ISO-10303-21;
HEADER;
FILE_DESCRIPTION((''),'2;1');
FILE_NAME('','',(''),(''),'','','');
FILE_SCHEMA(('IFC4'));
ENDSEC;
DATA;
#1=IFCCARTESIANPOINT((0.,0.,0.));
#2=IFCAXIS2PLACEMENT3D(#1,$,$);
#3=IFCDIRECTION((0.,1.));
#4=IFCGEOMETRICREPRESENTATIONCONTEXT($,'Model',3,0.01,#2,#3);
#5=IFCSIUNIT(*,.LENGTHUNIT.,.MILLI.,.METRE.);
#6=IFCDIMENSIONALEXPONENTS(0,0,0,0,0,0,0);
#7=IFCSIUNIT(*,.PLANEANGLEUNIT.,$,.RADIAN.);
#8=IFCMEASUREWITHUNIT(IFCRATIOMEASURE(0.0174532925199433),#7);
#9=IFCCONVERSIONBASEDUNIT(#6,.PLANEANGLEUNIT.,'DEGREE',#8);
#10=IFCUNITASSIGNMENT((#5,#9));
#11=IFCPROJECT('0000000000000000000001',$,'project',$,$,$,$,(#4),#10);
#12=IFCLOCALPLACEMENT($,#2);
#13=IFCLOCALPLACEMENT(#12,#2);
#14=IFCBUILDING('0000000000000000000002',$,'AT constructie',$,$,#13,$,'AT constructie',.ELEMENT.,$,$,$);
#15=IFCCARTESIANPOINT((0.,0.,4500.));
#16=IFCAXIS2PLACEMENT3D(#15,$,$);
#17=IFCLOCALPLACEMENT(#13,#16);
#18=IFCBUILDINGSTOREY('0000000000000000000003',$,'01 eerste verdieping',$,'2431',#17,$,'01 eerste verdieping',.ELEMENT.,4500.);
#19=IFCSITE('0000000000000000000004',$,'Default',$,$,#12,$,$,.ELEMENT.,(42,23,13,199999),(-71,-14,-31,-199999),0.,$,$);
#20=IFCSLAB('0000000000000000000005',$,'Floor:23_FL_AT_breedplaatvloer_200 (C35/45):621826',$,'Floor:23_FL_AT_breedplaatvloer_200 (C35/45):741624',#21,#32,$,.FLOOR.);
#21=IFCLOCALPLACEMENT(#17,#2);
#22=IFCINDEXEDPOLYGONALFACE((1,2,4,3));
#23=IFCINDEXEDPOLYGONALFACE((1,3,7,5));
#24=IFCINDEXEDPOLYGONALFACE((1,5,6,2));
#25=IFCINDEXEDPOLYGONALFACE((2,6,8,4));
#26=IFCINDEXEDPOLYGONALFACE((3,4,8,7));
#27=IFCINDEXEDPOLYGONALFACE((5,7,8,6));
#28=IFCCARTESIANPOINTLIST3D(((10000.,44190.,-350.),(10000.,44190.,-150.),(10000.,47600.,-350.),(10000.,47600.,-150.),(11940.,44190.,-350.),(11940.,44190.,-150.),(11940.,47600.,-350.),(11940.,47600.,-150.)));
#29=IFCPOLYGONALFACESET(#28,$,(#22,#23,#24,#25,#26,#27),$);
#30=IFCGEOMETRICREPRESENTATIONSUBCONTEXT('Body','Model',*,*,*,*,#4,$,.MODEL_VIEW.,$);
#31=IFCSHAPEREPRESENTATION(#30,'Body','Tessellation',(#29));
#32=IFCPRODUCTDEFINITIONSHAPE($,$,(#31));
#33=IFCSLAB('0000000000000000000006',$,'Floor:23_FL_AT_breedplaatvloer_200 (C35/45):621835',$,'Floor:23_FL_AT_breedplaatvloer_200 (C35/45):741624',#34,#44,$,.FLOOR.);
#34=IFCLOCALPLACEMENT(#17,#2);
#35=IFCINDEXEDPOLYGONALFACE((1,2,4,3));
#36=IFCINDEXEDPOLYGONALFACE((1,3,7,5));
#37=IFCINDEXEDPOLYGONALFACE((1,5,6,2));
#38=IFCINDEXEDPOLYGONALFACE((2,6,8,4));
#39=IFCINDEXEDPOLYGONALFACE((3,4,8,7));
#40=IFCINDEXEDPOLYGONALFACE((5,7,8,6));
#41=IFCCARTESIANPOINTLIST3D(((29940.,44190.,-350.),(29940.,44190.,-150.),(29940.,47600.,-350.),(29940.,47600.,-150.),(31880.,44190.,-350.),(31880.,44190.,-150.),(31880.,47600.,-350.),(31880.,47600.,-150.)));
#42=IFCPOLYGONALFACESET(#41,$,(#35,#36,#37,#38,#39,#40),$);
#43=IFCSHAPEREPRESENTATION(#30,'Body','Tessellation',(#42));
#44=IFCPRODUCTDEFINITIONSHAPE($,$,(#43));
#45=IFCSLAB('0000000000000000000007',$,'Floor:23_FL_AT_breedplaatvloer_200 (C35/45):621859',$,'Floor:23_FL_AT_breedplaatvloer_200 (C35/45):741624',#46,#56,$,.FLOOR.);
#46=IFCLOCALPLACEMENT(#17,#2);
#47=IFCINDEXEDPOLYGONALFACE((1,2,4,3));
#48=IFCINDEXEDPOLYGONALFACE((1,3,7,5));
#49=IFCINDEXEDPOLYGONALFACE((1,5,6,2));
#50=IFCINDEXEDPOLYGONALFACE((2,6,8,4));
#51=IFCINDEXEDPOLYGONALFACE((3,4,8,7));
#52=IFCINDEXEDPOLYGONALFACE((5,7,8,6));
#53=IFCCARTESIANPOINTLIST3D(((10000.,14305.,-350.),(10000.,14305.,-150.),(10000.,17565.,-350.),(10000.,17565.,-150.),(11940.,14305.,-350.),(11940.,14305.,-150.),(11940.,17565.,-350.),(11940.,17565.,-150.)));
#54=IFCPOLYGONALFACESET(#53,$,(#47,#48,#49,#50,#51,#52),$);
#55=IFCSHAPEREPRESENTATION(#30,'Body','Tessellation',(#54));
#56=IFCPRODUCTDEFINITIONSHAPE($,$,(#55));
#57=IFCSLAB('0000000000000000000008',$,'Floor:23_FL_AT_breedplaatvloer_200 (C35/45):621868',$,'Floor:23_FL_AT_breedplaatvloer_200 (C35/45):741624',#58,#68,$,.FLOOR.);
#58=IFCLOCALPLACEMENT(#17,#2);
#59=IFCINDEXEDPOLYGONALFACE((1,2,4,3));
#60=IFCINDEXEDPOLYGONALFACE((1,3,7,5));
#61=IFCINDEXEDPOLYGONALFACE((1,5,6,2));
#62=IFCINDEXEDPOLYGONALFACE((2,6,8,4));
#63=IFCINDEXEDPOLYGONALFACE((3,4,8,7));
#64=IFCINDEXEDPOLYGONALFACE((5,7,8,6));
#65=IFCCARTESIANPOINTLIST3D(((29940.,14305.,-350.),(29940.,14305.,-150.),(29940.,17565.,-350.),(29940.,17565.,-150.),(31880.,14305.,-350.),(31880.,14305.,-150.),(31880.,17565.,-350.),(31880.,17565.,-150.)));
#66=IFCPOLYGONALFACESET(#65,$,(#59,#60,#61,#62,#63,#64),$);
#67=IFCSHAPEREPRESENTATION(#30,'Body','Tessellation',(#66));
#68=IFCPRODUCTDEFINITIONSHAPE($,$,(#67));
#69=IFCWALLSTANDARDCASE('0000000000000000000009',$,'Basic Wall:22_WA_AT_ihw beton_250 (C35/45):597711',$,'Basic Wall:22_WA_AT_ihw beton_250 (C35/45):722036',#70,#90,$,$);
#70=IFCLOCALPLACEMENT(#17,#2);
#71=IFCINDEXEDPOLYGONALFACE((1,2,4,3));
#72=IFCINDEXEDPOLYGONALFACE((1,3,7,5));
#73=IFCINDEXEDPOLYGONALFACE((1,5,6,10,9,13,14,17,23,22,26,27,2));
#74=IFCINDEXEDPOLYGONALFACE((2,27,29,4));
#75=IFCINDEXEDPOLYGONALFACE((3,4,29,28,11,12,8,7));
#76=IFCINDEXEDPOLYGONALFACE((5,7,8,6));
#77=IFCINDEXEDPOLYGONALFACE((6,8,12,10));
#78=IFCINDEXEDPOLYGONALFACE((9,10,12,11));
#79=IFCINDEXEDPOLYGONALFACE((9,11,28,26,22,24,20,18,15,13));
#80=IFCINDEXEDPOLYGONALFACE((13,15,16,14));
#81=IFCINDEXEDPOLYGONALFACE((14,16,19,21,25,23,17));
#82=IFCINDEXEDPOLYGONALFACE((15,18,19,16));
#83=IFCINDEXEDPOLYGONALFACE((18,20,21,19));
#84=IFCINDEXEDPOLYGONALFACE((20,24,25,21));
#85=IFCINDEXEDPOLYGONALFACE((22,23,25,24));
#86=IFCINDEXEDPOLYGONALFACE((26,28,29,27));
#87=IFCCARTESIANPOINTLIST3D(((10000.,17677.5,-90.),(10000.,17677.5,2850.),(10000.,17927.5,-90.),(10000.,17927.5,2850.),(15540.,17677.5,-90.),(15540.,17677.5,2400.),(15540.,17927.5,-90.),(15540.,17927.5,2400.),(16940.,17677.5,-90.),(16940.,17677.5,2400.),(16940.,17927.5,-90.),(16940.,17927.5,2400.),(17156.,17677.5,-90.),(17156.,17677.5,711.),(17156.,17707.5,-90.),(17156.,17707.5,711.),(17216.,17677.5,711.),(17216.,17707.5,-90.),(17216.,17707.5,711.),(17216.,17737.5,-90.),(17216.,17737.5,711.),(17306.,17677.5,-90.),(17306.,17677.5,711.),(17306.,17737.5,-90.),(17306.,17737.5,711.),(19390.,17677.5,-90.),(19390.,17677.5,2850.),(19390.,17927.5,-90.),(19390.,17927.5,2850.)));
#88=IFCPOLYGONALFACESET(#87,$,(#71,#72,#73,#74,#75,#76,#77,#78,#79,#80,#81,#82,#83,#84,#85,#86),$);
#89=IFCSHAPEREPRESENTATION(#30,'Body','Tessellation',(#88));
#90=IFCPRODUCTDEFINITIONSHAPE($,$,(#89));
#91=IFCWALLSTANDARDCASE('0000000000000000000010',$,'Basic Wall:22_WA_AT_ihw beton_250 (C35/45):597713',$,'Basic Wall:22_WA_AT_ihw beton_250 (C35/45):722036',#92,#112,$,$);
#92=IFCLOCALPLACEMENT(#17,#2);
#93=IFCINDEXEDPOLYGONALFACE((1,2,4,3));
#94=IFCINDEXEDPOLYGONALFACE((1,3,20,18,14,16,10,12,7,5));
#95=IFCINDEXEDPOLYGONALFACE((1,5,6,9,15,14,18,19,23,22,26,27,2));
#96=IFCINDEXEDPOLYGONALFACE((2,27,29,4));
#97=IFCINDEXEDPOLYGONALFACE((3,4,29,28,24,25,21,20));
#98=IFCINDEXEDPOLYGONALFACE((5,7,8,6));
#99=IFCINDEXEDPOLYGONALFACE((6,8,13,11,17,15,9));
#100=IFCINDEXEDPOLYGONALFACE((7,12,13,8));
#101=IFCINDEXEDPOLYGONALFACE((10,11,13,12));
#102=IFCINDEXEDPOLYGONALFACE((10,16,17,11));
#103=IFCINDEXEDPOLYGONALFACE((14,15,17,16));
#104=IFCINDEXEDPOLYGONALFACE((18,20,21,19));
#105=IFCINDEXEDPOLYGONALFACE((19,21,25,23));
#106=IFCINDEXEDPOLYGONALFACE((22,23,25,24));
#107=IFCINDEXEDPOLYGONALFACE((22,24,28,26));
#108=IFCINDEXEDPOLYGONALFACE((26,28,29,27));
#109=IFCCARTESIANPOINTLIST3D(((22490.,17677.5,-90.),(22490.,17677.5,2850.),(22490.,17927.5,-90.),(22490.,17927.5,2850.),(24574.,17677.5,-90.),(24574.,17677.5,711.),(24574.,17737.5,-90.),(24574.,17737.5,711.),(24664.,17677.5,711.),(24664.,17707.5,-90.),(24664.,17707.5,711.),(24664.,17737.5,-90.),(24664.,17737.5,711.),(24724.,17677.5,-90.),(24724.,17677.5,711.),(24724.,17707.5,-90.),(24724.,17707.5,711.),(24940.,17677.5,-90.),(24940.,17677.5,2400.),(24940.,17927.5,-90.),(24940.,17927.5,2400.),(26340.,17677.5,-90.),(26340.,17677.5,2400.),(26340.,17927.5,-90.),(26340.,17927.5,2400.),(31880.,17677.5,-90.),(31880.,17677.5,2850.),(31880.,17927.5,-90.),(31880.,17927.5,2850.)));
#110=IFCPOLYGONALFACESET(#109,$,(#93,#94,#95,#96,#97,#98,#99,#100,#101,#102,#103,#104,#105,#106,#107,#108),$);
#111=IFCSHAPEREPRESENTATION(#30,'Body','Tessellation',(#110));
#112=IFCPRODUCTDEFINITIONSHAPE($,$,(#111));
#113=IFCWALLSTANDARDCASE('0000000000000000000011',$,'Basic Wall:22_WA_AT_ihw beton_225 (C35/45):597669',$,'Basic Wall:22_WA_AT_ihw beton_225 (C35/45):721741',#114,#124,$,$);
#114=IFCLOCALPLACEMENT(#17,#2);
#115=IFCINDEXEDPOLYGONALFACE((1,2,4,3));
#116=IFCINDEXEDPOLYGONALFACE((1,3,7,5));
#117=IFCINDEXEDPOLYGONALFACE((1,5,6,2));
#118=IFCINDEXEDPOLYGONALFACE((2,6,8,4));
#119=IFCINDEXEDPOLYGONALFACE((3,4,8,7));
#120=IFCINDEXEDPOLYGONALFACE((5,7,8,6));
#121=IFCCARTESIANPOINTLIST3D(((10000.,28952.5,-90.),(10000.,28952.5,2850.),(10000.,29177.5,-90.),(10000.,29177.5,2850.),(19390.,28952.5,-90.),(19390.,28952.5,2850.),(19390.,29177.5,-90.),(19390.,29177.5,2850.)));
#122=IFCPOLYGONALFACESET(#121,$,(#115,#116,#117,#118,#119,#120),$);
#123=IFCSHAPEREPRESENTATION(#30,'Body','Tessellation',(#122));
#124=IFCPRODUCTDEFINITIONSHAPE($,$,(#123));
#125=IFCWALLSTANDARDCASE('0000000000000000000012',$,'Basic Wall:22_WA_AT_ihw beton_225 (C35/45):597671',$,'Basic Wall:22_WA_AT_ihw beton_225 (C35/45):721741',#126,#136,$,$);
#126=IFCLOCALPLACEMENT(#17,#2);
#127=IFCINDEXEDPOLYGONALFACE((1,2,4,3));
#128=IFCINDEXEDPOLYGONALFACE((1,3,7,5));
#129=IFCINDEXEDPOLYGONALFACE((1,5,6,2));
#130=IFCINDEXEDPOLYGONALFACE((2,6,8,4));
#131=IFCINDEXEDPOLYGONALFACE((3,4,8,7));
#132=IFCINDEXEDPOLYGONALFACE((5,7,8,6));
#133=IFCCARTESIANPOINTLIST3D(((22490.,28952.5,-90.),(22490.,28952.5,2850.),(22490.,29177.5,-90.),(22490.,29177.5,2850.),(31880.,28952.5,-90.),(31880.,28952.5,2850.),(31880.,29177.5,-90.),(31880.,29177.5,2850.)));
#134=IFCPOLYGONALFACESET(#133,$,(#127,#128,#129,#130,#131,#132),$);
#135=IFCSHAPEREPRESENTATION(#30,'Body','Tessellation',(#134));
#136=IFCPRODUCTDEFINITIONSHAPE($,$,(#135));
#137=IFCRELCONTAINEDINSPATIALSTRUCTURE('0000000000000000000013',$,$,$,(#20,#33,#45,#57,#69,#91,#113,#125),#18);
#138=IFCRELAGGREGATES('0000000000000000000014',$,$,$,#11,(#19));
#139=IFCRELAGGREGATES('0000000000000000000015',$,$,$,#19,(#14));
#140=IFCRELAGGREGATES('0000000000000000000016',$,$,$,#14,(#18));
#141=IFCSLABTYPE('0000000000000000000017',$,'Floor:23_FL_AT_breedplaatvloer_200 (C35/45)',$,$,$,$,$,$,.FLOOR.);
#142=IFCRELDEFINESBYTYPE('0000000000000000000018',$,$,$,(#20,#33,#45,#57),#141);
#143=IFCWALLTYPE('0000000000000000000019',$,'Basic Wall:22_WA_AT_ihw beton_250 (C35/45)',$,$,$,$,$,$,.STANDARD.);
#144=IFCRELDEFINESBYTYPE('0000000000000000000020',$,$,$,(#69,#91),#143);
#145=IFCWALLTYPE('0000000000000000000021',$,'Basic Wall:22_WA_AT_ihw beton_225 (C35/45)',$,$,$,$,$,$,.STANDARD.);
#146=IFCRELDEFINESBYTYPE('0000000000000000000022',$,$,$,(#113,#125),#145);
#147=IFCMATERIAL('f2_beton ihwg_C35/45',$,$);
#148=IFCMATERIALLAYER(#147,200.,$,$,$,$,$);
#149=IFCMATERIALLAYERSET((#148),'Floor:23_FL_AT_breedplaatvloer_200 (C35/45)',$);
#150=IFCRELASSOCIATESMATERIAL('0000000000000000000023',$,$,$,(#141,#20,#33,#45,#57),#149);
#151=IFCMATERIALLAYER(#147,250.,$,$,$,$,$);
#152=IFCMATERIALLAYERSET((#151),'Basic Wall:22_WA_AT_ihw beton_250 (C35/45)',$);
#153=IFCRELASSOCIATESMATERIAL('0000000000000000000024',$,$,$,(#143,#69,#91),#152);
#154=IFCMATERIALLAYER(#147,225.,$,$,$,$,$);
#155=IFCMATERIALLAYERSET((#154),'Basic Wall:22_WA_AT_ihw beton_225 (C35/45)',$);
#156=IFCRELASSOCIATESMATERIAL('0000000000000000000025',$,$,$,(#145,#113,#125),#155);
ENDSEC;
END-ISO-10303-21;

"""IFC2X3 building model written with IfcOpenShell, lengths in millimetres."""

from ifc_helpers import new_model, entity, si_unit, converted_unit, direction, frame, frame_2d, origin, place, context, subcontext, project, spatial, rectangle, extrude, material, layer, layer_set, layer_usage, type_object, element, save


model = new_model("IFC2X3")

# Units and contexts
model_context = context("Model", 3, precision=0.01, world=origin(), true_north=direction((0.0, 1.0)))
body_context = subcontext(model_context, "Body", "Model", "MODEL_VIEW")
ifc_project = project(units=[si_unit("LENGTHUNIT", "METRE", prefix="MILLI"), converted_unit("PLANEANGLEUNIT", "DEGREE", entity("IfcRatioMeasure", 0.0174532925199433), si_unit("PLANEANGLEUNIT", "RADIAN"), dimensions=[0, 0, 0, 0, 0, 0, 0])], contexts=[model_context])

# Site, building, storey
site_placement = place(None, origin())
site = spatial("IfcSite", under=ifc_project, at=site_placement, Name="Default", CompositionType="ELEMENT", RefLatitude=(42, 23, 13, 199999), RefLongitude=(-71, -14, -31, -199999), RefElevation=0.0)
building_placement = place(site_placement, origin())
building = spatial("IfcBuilding", under=site, at=building_placement, Name="AT constructie", LongName="AT constructie", CompositionType="ELEMENT")
storey_placement = place(building_placement, frame((0.0, 0.0, 4500.0)))
storey = spatial("IfcBuildingStorey", under=building, at=storey_placement, Name="01 eerste verdieping", ObjectType="2431", LongName="01 eerste verdieping", CompositionType="ELEMENT", Elevation=4500.0)

# Shared definitions
ifc_material_1 = material(Name="f2_beton ihwg_C35/45")

# Slabs
ifc_layer_1 = layer(ifc_material_1, 200.0)
ifc_layer_set_1 = layer_set([ifc_layer_1], Name="Floor:23_FL_AT_breedplaatvloer_200 (C35/45)")
slab_type_1 = type_object("IfcSlabType", Name="Floor:23_FL_AT_breedplaatvloer_200 (C35/45)", PredefinedType="FLOOR", material=ifc_layer_set_1)
ifc_layer_usage_1 = layer_usage(ifc_layer_set_1, "AXIS3", "POSITIVE", 0.0)
slab_1_placement = place(storey_placement, origin())
element("IfcSlab", 1, at=slab_1_placement, inside=storey, type_object=slab_type_1, material=ifc_layer_usage_1, Name="Floor:23_FL_AT_breedplaatvloer_200 (C35/45):621826", ObjectType="Floor:23_FL_AT_breedplaatvloer_200 (C35/45):741624", PredefinedType="FLOOR", context=body_context, shape_type="SweptSolid", body=[
    extrude(rectangle(XDim=3410.0, YDim=1940.0, at=frame_2d((0.0, 0.0), x_axis=(1.0, 0.0))), frame((10970.0, 45895.0, -150.0), z_axis=(0.0, 0.0, -1.0), x_axis=(0.0, 1.0, 0.0)), (0.0, 0.0, 1.0), 200.0),
])
ifc_layer_usage_2 = layer_usage(ifc_layer_set_1, "AXIS3", "POSITIVE", 0.0)
slab_2_placement = place(storey_placement, origin())
element("IfcSlab", 2, at=slab_2_placement, inside=storey, type_object=slab_type_1, material=ifc_layer_usage_2, Name="Floor:23_FL_AT_breedplaatvloer_200 (C35/45):621835", ObjectType="Floor:23_FL_AT_breedplaatvloer_200 (C35/45):741624", PredefinedType="FLOOR", context=body_context, shape_type="SweptSolid", body=[
    extrude(rectangle(XDim=3410.0, YDim=1940.0, at=frame_2d((0.0, 0.0), x_axis=(1.0, 0.0))), frame((30910.0, 45895.0, -150.0), z_axis=(0.0, 0.0, -1.0), x_axis=(0.0, 1.0, 0.0)), (0.0, 0.0, 1.0), 200.0),
])
ifc_layer_usage_3 = layer_usage(ifc_layer_set_1, "AXIS3", "POSITIVE", 0.0)
slab_3_placement = place(storey_placement, origin())
element("IfcSlab", 3, at=slab_3_placement, inside=storey, type_object=slab_type_1, material=ifc_layer_usage_3, Name="Floor:23_FL_AT_breedplaatvloer_200 (C35/45):621859", ObjectType="Floor:23_FL_AT_breedplaatvloer_200 (C35/45):741624", PredefinedType="FLOOR", context=body_context, shape_type="SweptSolid", body=[
    extrude(rectangle(XDim=3260.0, YDim=1940.0, at=frame_2d((0.0, 0.0), x_axis=(1.0, 0.0))), frame((10970.0, 15935.0, -150.0), z_axis=(0.0, 0.0, -1.0), x_axis=(0.0, 1.0, 0.0)), (0.0, 0.0, 1.0), 200.0),
])
ifc_layer_usage_4 = layer_usage(ifc_layer_set_1, "AXIS3", "POSITIVE", 0.0)
slab_4_placement = place(storey_placement, origin())
element("IfcSlab", 4, at=slab_4_placement, inside=storey, type_object=slab_type_1, material=ifc_layer_usage_4, Name="Floor:23_FL_AT_breedplaatvloer_200 (C35/45):621868", ObjectType="Floor:23_FL_AT_breedplaatvloer_200 (C35/45):741624", PredefinedType="FLOOR", context=body_context, shape_type="SweptSolid", body=[
    extrude(rectangle(XDim=3260.0, YDim=1940.0, at=frame_2d((0.0, 0.0), x_axis=(1.0, 0.0))), frame((30910.0, 15935.0, -150.0), z_axis=(0.0, 0.0, -1.0), x_axis=(0.0, 1.0, 0.0)), (0.0, 0.0, 1.0), 200.0),
])

# Walls, openings
ifc_layer_2 = layer(ifc_material_1, 250.0)
ifc_layer_set_2 = layer_set([ifc_layer_2], Name="Basic Wall:22_WA_AT_ihw beton_250 (C35/45)")
ifc_layer_usage_5 = layer_usage(ifc_layer_set_2, "AXIS2", "NEGATIVE", 125.0)
wall_type_1 = type_object("IfcWallType", Name="Basic Wall:22_WA_AT_ihw beton_250 (C35/45)", PredefinedType="STANDARD", material=ifc_layer_set_2)
wall_1_placement = place(storey_placement, frame((10000.0, 17802.5, -90.0)))
wall_1 = element("IfcWallStandardCase", 5, at=wall_1_placement, inside=storey, type_object=wall_type_1, material=ifc_layer_usage_5, Name="Basic Wall:22_WA_AT_ihw beton_250 (C35/45):597711", ObjectType="Basic Wall:22_WA_AT_ihw beton_250 (C35/45):722036", context=body_context, shape_type="SweptSolid", body=[
    extrude(rectangle(XDim=9390.0, YDim=250.0, at=frame_2d((4695.0, 0.0), x_axis=(-1.0, 0.0))), origin(), (0.0, 0.0, 1.0), 2940.0),
])
opening_1_placement = place(wall_1_placement, origin())
element("IfcOpeningElement", 6, at=opening_1_placement, cuts=wall_1, ObjectType="Opening", context=body_context, shape_type="SweptSolid", body=[
    extrude(rectangle(XDim=2490.0, YDim=1400.0, at=frame_2d((0.0, 0.0), x_axis=(1.0, 0.0))), frame((6240.0, -1399.0, 1245.0), z_axis=(0.0, 1.0, 0.0), x_axis=(0.0, 0.0, -1.0)), (0.0, 0.0, 1.0), 3048.0),
])
opening_2_placement = place(wall_1_placement, origin())
element("IfcOpeningElement", 7, at=opening_2_placement, cuts=wall_1, ObjectType="Recess", context=body_context, shape_type="SweptSolid", body=[
    extrude(rectangle(XDim=801.0, YDim=90.0, at=frame_2d((0.0, 0.0), x_axis=(1.0, 0.0))), frame((7261.0, -125.0, 400.5), z_axis=(0.0, 1.0, 0.0), x_axis=(0.0, 0.0, -1.0)), (0.0, 0.0, 1.0), 60.0),
])
opening_3_placement = place(wall_1_placement, origin())
element("IfcOpeningElement", 8, at=opening_3_placement, cuts=wall_1, ObjectType="Recess", context=body_context, shape_type="SweptSolid", body=[
    extrude(rectangle(XDim=801.0, YDim=60.0, at=frame_2d((0.0, 0.0), x_axis=(1.0, 0.0))), frame((7186.0, -125.0, 400.5), z_axis=(0.0, 1.0, 0.0), x_axis=(0.0, 0.0, -1.0)), (0.0, 0.0, 1.0), 30.0),
])
ifc_layer_usage_6 = layer_usage(ifc_layer_set_2, "AXIS2", "NEGATIVE", 125.0)
wall_2_placement = place(storey_placement, frame((22490.0, 17802.5, -90.0)))
wall_2 = element("IfcWallStandardCase", 9, at=wall_2_placement, inside=storey, type_object=wall_type_1, material=ifc_layer_usage_6, Name="Basic Wall:22_WA_AT_ihw beton_250 (C35/45):597713", ObjectType="Basic Wall:22_WA_AT_ihw beton_250 (C35/45):722036", context=body_context, shape_type="SweptSolid", body=[
    extrude(rectangle(XDim=9390.0, YDim=250.0, at=frame_2d((4695.0, 0.0), x_axis=(-1.0, 0.0))), origin(), (0.0, 0.0, 1.0), 2940.0),
])
opening_4_placement = place(wall_2_placement, origin())
element("IfcOpeningElement", 10, at=opening_4_placement, cuts=wall_2, ObjectType="Opening", context=body_context, shape_type="SweptSolid", body=[
    extrude(rectangle(XDim=2490.0, YDim=1400.0, at=frame_2d((0.0, 0.0), x_axis=(1.0, 0.0))), frame((3150.0, -1399.0, 1245.0), z_axis=(0.0, 1.0, 0.0), x_axis=(0.0, 0.0, -1.0)), (0.0, 0.0, 1.0), 3048.0),
])
opening_5_placement = place(wall_2_placement, origin())
element("IfcOpeningElement", 11, at=opening_5_placement, cuts=wall_2, ObjectType="Recess", context=body_context, shape_type="SweptSolid", body=[
    extrude(rectangle(XDim=801.0, YDim=90.0, at=frame_2d((0.0, 0.0), x_axis=(1.0, 0.0))), frame((2129.0, -125.0, 400.5), z_axis=(0.0, 1.0, 0.0), x_axis=(0.0, 0.0, -1.0)), (0.0, 0.0, 1.0), 60.0),
])
opening_6_placement = place(wall_2_placement, origin())
element("IfcOpeningElement", 12, at=opening_6_placement, cuts=wall_2, ObjectType="Recess", context=body_context, shape_type="SweptSolid", body=[
    extrude(rectangle(XDim=801.0, YDim=60.0, at=frame_2d((0.0, 0.0), x_axis=(1.0, 0.0))), frame((2204.0, -125.0, 400.5), z_axis=(0.0, 1.0, 0.0), x_axis=(0.0, 0.0, -1.0)), (0.0, 0.0, 1.0), 30.0),
])

# Walls
ifc_layer_3 = layer(ifc_material_1, 225.0)
ifc_layer_set_3 = layer_set([ifc_layer_3], Name="Basic Wall:22_WA_AT_ihw beton_225 (C35/45)")
ifc_layer_usage_7 = layer_usage(ifc_layer_set_3, "AXIS2", "NEGATIVE", 112.5)
wall_type_2 = type_object("IfcWallType", Name="Basic Wall:22_WA_AT_ihw beton_225 (C35/45)", PredefinedType="STANDARD", material=ifc_layer_set_3)
wall_3_placement = place(storey_placement, frame((10000.0, 29065.0, -90.0)))
element("IfcWallStandardCase", 13, at=wall_3_placement, inside=storey, type_object=wall_type_2, material=ifc_layer_usage_7, Name="Basic Wall:22_WA_AT_ihw beton_225 (C35/45):597669", ObjectType="Basic Wall:22_WA_AT_ihw beton_225 (C35/45):721741", context=body_context, shape_type="SweptSolid", body=[
    extrude(rectangle(XDim=9390.0, YDim=225.0, at=frame_2d((4695.0, 0.0), x_axis=(-1.0, 0.0))), origin(), (0.0, 0.0, 1.0), 2940.0),
])
ifc_layer_usage_8 = layer_usage(ifc_layer_set_3, "AXIS2", "NEGATIVE", 112.5)
wall_4_placement = place(storey_placement, frame((22490.0, 29065.0, -90.0)))
element("IfcWallStandardCase", 14, at=wall_4_placement, inside=storey, type_object=wall_type_2, material=ifc_layer_usage_8, Name="Basic Wall:22_WA_AT_ihw beton_225 (C35/45):597671", ObjectType="Basic Wall:22_WA_AT_ihw beton_225 (C35/45):721741", context=body_context, shape_type="SweptSolid", body=[
    extrude(rectangle(XDim=9390.0, YDim=225.0, at=frame_2d((4695.0, 0.0), x_axis=(-1.0, 0.0))), origin(), (0.0, 0.0, 1.0), 2940.0),
])

save(model, "model.ifc")
